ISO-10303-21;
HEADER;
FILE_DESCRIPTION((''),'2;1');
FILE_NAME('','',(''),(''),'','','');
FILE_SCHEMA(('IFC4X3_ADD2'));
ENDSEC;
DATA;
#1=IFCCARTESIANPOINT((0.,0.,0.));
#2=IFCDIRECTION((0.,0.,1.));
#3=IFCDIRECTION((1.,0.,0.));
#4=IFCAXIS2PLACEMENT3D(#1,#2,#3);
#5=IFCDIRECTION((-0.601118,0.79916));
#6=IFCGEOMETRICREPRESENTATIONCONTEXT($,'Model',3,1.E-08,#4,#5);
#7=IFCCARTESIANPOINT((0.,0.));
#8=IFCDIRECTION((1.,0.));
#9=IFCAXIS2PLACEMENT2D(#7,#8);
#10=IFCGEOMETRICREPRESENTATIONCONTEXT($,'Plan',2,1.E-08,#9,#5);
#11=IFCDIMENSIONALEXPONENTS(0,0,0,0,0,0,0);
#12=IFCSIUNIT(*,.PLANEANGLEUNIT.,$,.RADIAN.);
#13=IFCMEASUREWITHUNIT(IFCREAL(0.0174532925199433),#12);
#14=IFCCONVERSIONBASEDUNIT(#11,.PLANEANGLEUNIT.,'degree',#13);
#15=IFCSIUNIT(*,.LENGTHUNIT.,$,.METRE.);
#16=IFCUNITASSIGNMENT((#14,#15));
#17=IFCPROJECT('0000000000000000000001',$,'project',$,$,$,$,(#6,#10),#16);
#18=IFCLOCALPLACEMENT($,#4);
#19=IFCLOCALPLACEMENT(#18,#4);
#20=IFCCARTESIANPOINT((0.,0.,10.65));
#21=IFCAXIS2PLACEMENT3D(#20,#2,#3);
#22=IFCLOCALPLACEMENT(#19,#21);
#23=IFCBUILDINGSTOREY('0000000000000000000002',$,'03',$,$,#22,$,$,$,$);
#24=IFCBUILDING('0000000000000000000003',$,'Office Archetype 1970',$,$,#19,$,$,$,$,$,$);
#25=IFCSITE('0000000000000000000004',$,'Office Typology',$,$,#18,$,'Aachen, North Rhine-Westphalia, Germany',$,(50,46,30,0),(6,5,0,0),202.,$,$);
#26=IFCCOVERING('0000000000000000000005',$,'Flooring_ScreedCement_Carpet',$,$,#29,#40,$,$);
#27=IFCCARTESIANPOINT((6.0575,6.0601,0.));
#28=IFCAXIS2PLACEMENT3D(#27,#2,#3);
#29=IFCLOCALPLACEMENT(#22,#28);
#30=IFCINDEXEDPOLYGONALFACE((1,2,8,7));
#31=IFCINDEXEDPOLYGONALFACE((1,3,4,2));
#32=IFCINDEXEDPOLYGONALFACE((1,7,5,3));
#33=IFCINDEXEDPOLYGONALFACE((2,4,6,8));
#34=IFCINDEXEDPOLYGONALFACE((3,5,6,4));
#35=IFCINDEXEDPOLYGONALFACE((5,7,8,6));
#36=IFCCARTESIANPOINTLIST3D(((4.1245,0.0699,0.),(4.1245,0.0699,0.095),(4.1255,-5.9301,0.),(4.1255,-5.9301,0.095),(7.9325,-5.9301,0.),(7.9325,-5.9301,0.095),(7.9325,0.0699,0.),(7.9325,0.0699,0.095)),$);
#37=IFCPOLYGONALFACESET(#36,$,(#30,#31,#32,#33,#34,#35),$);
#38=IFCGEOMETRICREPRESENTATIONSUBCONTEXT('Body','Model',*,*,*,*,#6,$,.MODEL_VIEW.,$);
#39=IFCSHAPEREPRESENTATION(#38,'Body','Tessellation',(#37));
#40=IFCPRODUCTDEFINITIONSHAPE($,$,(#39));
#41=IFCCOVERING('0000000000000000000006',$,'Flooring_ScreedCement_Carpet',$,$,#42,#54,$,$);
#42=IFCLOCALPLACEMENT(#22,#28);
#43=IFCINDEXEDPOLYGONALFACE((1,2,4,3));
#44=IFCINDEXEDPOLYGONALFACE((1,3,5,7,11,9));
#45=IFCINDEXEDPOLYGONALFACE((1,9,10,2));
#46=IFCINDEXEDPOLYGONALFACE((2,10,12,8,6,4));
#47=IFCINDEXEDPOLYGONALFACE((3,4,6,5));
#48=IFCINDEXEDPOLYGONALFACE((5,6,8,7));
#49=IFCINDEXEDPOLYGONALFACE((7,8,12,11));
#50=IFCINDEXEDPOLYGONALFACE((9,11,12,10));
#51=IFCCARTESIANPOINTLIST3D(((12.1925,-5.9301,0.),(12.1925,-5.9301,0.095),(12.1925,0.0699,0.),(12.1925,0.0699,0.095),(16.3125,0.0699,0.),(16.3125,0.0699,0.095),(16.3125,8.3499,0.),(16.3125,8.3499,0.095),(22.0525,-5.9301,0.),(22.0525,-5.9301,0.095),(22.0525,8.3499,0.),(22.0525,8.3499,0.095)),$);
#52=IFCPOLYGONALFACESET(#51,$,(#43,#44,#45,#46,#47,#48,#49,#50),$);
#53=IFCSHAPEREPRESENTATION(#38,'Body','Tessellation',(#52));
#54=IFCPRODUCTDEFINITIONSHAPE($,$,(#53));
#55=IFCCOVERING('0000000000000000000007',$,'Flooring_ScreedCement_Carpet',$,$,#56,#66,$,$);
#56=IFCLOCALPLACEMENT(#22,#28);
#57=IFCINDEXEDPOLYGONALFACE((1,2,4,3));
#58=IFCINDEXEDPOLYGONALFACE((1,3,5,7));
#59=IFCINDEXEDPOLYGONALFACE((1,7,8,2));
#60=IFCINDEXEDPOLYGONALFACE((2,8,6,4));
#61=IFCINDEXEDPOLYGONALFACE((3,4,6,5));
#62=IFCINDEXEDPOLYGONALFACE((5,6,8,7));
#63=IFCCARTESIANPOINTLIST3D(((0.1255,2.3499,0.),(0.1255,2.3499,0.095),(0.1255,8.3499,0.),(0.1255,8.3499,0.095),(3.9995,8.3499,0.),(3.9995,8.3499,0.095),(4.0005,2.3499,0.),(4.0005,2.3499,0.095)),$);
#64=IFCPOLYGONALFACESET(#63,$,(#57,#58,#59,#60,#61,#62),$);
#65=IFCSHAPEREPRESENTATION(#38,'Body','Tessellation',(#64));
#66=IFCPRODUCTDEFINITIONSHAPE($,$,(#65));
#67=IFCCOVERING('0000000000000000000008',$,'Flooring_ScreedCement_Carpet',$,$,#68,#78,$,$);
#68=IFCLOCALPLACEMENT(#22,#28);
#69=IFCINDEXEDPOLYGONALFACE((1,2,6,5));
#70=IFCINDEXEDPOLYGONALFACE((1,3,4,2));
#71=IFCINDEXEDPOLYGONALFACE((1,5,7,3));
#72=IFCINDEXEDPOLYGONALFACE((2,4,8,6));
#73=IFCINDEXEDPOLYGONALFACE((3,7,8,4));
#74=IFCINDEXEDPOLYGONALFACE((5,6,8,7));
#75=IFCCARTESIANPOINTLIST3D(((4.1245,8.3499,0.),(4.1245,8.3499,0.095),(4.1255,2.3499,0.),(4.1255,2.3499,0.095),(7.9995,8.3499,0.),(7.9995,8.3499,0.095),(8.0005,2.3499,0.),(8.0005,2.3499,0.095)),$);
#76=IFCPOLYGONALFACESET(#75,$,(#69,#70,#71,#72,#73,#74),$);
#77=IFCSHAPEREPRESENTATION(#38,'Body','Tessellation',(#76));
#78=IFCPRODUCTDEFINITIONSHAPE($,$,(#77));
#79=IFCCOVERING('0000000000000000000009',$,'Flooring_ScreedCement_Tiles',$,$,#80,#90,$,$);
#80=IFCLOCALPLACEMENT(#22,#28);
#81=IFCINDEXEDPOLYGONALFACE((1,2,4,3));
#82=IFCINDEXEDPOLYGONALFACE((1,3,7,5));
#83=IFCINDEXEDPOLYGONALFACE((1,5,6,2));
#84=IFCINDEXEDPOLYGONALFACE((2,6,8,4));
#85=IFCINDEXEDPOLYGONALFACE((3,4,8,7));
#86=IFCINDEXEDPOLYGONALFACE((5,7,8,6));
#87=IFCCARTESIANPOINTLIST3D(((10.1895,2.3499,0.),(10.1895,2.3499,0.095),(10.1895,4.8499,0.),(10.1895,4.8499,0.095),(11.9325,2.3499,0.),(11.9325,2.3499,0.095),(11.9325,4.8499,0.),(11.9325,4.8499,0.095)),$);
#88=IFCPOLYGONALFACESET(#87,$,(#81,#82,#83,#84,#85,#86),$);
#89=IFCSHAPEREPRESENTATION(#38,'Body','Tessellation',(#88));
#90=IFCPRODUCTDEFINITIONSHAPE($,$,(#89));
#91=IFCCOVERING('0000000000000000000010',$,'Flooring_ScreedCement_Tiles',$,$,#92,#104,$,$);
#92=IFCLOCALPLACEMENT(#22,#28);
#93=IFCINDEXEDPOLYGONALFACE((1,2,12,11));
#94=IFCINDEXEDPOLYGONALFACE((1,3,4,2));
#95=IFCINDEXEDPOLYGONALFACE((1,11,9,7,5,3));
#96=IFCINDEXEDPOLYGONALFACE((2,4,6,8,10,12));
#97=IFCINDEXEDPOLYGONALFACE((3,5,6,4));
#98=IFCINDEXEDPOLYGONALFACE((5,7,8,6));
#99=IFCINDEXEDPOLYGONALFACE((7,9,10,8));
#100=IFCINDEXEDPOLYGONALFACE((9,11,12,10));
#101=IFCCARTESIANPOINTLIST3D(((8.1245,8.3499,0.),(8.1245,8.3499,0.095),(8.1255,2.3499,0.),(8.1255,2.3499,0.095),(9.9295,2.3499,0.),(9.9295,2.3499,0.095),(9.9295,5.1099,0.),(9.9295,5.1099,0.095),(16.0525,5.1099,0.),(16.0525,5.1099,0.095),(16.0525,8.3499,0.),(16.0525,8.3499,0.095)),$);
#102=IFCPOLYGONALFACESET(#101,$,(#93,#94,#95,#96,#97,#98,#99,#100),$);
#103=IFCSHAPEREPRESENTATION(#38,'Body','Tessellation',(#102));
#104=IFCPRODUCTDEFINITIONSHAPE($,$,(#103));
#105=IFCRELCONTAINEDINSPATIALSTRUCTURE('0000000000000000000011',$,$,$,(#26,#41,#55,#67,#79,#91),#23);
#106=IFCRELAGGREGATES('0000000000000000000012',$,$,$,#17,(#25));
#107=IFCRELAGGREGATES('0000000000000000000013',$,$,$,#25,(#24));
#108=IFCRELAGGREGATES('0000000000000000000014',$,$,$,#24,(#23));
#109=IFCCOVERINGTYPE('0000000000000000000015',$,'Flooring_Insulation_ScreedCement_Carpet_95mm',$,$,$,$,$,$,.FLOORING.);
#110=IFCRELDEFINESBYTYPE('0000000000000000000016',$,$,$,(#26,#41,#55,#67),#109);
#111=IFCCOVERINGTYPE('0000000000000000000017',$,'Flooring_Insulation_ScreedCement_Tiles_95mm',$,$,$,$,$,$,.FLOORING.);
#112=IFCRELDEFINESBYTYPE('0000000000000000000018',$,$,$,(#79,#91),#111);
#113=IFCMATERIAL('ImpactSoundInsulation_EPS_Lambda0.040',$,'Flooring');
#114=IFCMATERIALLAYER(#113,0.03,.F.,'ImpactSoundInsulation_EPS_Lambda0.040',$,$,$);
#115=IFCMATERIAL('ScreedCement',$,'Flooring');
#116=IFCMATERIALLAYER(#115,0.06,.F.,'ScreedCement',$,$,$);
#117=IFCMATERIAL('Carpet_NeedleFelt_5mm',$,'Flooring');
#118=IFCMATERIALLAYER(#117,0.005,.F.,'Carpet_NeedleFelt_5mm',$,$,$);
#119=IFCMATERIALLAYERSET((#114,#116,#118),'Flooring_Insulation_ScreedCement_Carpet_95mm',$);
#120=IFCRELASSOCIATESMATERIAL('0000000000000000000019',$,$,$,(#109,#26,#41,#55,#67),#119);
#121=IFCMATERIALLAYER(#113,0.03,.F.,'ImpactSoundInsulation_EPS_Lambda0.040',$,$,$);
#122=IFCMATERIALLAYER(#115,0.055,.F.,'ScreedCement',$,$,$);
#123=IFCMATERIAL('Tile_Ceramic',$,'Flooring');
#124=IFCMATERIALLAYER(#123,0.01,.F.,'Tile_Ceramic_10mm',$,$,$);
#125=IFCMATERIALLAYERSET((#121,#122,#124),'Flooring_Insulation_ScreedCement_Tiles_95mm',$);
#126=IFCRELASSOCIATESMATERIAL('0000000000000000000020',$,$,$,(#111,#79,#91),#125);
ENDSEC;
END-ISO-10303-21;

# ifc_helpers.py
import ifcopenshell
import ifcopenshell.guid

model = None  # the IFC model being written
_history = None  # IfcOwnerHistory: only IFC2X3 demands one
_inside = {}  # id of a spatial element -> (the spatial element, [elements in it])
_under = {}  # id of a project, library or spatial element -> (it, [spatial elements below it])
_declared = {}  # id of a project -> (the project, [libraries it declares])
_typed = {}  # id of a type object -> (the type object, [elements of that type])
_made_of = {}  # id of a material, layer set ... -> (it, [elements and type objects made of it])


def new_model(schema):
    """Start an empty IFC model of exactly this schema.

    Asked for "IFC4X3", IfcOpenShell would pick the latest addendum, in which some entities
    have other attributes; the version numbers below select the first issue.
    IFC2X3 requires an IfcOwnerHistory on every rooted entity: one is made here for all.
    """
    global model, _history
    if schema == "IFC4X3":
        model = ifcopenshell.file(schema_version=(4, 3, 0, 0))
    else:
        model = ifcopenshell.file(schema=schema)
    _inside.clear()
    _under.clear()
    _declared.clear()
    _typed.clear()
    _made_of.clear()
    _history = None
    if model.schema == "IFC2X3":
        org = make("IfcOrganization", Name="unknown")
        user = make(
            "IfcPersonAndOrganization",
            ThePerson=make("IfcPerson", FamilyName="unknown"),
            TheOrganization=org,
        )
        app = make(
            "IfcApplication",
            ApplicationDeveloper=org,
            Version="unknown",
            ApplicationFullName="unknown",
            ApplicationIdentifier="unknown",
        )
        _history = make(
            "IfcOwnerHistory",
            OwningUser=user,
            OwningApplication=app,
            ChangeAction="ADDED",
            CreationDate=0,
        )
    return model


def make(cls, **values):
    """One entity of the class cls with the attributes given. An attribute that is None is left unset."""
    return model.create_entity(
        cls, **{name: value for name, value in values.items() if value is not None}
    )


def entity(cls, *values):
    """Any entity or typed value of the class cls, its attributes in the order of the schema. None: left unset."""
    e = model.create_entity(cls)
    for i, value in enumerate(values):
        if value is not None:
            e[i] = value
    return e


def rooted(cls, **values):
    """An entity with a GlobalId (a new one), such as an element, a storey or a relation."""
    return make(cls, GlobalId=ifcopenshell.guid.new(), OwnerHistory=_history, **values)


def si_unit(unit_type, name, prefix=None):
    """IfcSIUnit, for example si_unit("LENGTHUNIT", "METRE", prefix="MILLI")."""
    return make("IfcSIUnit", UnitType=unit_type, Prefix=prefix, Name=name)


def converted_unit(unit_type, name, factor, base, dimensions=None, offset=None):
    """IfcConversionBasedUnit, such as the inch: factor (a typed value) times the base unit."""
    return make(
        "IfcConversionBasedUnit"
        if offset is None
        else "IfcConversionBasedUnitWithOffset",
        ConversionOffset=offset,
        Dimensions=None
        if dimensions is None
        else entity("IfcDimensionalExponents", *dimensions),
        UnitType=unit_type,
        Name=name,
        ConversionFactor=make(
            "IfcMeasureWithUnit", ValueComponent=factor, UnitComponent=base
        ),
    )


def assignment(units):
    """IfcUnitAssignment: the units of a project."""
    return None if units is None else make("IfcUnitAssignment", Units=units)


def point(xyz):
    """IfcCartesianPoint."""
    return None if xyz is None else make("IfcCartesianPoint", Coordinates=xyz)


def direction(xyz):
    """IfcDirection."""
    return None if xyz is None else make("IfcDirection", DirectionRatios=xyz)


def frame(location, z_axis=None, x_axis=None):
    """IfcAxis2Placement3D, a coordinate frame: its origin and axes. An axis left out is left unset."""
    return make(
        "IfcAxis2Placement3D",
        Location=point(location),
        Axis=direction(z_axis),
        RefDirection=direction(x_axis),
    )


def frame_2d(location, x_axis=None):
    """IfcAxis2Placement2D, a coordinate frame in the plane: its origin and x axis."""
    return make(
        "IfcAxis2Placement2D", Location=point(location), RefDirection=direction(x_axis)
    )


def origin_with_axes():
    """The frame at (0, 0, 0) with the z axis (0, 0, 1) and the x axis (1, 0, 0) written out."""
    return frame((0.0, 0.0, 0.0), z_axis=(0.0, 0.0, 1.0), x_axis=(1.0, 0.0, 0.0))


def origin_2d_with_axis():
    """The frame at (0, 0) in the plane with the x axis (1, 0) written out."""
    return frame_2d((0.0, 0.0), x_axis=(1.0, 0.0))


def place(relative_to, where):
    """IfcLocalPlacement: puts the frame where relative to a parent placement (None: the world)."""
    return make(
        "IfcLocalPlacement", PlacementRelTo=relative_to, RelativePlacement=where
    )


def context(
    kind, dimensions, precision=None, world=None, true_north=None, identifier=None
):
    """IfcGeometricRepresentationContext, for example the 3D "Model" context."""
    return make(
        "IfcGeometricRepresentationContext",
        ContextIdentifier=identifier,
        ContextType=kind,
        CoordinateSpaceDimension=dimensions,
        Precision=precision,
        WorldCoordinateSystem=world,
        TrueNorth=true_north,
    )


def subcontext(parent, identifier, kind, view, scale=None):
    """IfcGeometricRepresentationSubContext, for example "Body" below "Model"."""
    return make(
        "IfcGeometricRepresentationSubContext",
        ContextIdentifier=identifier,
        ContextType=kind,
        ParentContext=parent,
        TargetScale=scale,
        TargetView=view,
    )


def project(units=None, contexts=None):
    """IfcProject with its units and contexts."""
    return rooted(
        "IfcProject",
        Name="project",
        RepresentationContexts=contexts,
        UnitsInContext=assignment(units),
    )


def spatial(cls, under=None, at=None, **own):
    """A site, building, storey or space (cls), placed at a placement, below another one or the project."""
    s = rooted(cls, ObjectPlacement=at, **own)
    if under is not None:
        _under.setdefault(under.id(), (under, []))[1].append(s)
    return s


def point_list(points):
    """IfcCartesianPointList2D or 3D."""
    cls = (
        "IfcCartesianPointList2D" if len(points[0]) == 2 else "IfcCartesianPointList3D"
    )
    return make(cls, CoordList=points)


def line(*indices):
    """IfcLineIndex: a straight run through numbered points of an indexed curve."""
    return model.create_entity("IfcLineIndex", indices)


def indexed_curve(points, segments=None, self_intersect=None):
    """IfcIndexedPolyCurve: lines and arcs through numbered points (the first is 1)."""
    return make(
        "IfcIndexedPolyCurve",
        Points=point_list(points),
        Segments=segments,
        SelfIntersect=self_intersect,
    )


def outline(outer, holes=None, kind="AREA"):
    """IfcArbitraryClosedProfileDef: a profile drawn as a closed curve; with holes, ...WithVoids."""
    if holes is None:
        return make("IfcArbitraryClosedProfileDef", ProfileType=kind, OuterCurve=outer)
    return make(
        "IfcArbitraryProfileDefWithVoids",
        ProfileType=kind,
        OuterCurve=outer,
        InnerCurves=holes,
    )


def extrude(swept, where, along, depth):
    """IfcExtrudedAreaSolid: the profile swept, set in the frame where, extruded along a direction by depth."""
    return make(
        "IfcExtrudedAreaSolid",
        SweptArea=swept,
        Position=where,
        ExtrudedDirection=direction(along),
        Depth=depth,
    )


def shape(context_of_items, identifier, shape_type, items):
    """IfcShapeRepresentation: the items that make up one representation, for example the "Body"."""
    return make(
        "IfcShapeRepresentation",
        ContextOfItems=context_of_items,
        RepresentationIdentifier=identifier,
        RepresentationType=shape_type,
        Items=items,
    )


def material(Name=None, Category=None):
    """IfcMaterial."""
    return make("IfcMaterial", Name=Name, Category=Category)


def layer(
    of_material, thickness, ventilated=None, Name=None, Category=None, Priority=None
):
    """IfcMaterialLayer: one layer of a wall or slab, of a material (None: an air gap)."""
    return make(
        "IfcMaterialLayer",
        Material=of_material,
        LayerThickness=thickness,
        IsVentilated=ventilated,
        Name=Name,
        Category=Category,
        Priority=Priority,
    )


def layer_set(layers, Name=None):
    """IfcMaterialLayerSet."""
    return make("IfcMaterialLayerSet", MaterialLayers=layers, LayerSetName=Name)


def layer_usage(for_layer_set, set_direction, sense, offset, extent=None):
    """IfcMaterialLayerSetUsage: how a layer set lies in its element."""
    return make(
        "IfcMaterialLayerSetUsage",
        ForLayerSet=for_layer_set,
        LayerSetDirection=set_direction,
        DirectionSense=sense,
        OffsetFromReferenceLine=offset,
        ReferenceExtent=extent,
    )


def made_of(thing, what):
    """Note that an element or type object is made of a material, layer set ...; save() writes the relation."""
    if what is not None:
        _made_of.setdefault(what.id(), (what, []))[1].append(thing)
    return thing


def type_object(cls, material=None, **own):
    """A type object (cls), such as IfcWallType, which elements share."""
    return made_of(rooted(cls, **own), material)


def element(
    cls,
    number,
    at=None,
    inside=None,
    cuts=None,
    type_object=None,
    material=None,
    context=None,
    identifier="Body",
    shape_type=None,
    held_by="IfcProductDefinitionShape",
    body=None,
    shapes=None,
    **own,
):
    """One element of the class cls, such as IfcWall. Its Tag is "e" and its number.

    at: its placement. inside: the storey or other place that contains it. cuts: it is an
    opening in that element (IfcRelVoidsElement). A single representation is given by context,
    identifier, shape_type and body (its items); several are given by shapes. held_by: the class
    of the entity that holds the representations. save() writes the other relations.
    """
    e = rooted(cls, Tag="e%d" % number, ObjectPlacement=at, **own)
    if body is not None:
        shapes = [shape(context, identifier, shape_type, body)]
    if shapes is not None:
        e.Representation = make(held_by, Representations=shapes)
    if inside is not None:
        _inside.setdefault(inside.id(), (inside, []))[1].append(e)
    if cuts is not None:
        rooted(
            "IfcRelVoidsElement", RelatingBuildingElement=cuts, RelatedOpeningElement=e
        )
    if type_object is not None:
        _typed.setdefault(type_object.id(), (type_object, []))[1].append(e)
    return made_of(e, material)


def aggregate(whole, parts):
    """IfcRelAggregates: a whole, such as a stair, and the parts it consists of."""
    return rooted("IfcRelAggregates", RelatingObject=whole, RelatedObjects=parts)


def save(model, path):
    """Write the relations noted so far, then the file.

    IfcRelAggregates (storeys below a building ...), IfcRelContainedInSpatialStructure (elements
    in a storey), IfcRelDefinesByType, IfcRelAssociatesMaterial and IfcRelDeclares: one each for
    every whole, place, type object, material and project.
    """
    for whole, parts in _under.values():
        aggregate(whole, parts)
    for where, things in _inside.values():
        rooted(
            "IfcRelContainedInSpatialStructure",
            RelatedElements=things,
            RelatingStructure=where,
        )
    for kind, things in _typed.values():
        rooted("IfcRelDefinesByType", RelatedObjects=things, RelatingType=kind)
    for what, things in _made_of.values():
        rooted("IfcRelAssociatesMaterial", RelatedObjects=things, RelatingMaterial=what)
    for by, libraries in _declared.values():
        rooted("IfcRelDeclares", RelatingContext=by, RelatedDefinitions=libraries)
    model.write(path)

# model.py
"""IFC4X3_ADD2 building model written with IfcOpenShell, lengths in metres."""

from ifc_helpers import new_model, entity, si_unit, converted_unit, direction, frame, origin_with_axes, origin_2d_with_axis, place, context, subcontext, project, spatial, line, indexed_curve, outline, extrude, material, layer, layer_set, layer_usage, type_object, element, save


model = new_model("IFC4X3_ADD2")

# Units and contexts
model_context = context("Model", 3, precision=1e-08, world=origin_with_axes(), true_north=direction((-0.601118, 0.79916)))
plan_context = context("Plan", 2, precision=1e-08, world=origin_2d_with_axis(), true_north=direction((-0.601118, 0.79916)))
body_context = subcontext(model_context, "Body", "Model", "MODEL_VIEW")
ifc_project = project(units=[converted_unit("PLANEANGLEUNIT", "degree", entity("IfcReal", 0.0174532925199433), si_unit("PLANEANGLEUNIT", "RADIAN"), dimensions=[0, 0, 0, 0, 0, 0, 0]), si_unit("LENGTHUNIT", "METRE")], contexts=[model_context, plan_context])

# Site, building, storey
site_placement = place(None, origin_with_axes())
site = spatial("IfcSite", under=ifc_project, at=site_placement, Name="Office Typology", LongName="Aachen, North Rhine-Westphalia, Germany", RefLatitude=(50, 46, 30, 0), RefLongitude=(6, 5, 0, 0), RefElevation=202.0)
building_placement = place(site_placement, origin_with_axes())
building = spatial("IfcBuilding", under=site, at=building_placement, Name="Office Archetype 1970")
storey_placement = place(building_placement, frame((0.0, 0.0, 10.65), z_axis=(0.0, 0.0, 1.0), x_axis=(1.0, 0.0, 0.0)))
storey = spatial("IfcBuildingStorey", under=building, at=storey_placement, Name="03")

# Coverings
ifc_material_1 = material(Name="ImpactSoundInsulation_EPS_Lambda0.040", Category="Flooring")
ifc_layer_1 = layer(ifc_material_1, 0.03, ventilated=False, Name="ImpactSoundInsulation_EPS_Lambda0.040")
ifc_material_2 = material(Name="ScreedCement", Category="Flooring")
ifc_layer_2 = layer(ifc_material_2, 0.06, ventilated=False, Name="ScreedCement")
ifc_material_3 = material(Name="Carpet_NeedleFelt_5mm", Category="Flooring")
ifc_layer_3 = layer(ifc_material_3, 0.005, ventilated=False, Name="Carpet_NeedleFelt_5mm")
ifc_layer_set_1 = layer_set([ifc_layer_1, ifc_layer_2, ifc_layer_3], Name="Flooring_Insulation_ScreedCement_Carpet_95mm")
ifc_layer_usage_1 = layer_usage(ifc_layer_set_1, "AXIS3", "POSITIVE", 0.0)
covering_type_1 = type_object("IfcCoveringType", Name="Flooring_Insulation_ScreedCement_Carpet_95mm", PredefinedType="FLOORING", material=ifc_layer_set_1)
covering_1_placement = place(storey_placement, frame((6.0575, 6.0601, 0.0), z_axis=(0.0, 0.0, 1.0), x_axis=(1.0, 0.0, 0.0)))
element("IfcCovering", 1, at=covering_1_placement, inside=storey, type_object=covering_type_1, material=ifc_layer_usage_1, Name="Flooring_ScreedCement_Carpet", context=body_context, shape_type="SweptSolid", body=[
    extrude(outline(indexed_curve([(4.1245, 0.0699), (7.9325, 0.0699), (7.9325, -5.9301), (4.1255, -5.9301)], segments=[line(1, 2, 3, 4, 1)])), origin_with_axes(), (0.0, 0.0, 1.0), 0.095),
])
ifc_layer_usage_2 = layer_usage(ifc_layer_set_1, "AXIS3", "POSITIVE", 0.0)
covering_2_placement = place(storey_placement, frame((6.0575, 6.0601, 0.0), z_axis=(0.0, 0.0, 1.0), x_axis=(1.0, 0.0, 0.0)))
element("IfcCovering", 2, at=covering_2_placement, inside=storey, type_object=covering_type_1, material=ifc_layer_usage_2, Name="Flooring_ScreedCement_Carpet", context=body_context, shape_type="SweptSolid", body=[
    extrude(outline(indexed_curve([(16.3125, 8.3499), (22.0525, 8.3499), (22.0525, -5.9301), (12.1925, -5.9301), (12.1925, 0.0699), (16.3125, 0.0699)], segments=[line(1, 2, 3, 4, 5, 6, 1)])), origin_with_axes(), (0.0, 0.0, 1.0), 0.095),
])
ifc_layer_usage_3 = layer_usage(ifc_layer_set_1, "AXIS3", "POSITIVE", 0.0)
covering_3_placement = place(storey_placement, frame((6.0575, 6.0601, 0.0), z_axis=(0.0, 0.0, 1.0), x_axis=(1.0, 0.0, 0.0)))
element("IfcCovering", 3, at=covering_3_placement, inside=storey, type_object=covering_type_1, material=ifc_layer_usage_3, Name="Flooring_ScreedCement_Carpet", context=body_context, shape_type="SweptSolid", body=[
    extrude(outline(indexed_curve([(0.1255, 2.3499), (0.1255, 8.3499), (3.9995, 8.3499), (4.0005, 2.3499)], segments=[line(1, 2, 3, 4, 1)])), origin_with_axes(), (0.0, 0.0, 1.0), 0.095),
])
ifc_layer_usage_4 = layer_usage(ifc_layer_set_1, "AXIS3", "POSITIVE", 0.0)
covering_4_placement = place(storey_placement, frame((6.0575, 6.0601, 0.0), z_axis=(0.0, 0.0, 1.0), x_axis=(1.0, 0.0, 0.0)))
element("IfcCovering", 4, at=covering_4_placement, inside=storey, type_object=covering_type_1, material=ifc_layer_usage_4, Name="Flooring_ScreedCement_Carpet", context=body_context, shape_type="SweptSolid", body=[
    extrude(outline(indexed_curve([(4.1255, 2.3499), (4.1245, 8.3499), (7.9995, 8.3499), (8.0005, 2.3499)], segments=[line(1, 2, 3, 4, 1)])), origin_with_axes(), (0.0, 0.0, 1.0), 0.095),
])
ifc_layer_4 = layer(ifc_material_1, 0.03, ventilated=False, Name="ImpactSoundInsulation_EPS_Lambda0.040")
ifc_layer_5 = layer(ifc_material_2, 0.055, ventilated=False, Name="ScreedCement")
ifc_material_4 = material(Name="Tile_Ceramic", Category="Flooring")
ifc_layer_6 = layer(ifc_material_4, 0.01, ventilated=False, Name="Tile_Ceramic_10mm")
ifc_layer_set_2 = layer_set([ifc_layer_4, ifc_layer_5, ifc_layer_6], Name="Flooring_Insulation_ScreedCement_Tiles_95mm")
ifc_layer_usage_5 = layer_usage(ifc_layer_set_2, "AXIS3", "POSITIVE", 0.0)
covering_type_2 = type_object("IfcCoveringType", Name="Flooring_Insulation_ScreedCement_Tiles_95mm", PredefinedType="FLOORING", material=ifc_layer_set_2)
covering_5_placement = place(storey_placement, frame((6.0575, 6.0601, 0.0), z_axis=(0.0, 0.0, 1.0), x_axis=(1.0, 0.0, 0.0)))
element("IfcCovering", 5, at=covering_5_placement, inside=storey, type_object=covering_type_2, material=ifc_layer_usage_5, Name="Flooring_ScreedCement_Tiles", context=body_context, shape_type="SweptSolid", body=[
    extrude(outline(indexed_curve([(11.9325, 4.8499), (11.9325, 2.3499), (10.1895, 2.3499), (10.1895, 4.8499)], segments=[line(1, 2, 3, 4, 1)])), None, (0.0, 0.0, 1.0), 0.095),
])
ifc_layer_usage_6 = layer_usage(ifc_layer_set_2, "AXIS3", "POSITIVE", 0.0)
covering_6_placement = place(storey_placement, frame((6.0575, 6.0601, 0.0), z_axis=(0.0, 0.0, 1.0), x_axis=(1.0, 0.0, 0.0)))
element("IfcCovering", 6, at=covering_6_placement, inside=storey, type_object=covering_type_2, material=ifc_layer_usage_6, Name="Flooring_ScreedCement_Tiles", context=body_context, shape_type="SweptSolid", body=[
    extrude(outline(indexed_curve([(9.9295, 5.1099), (9.9295, 2.3499), (8.1255, 2.3499), (8.1245, 8.3499), (16.0525, 8.3499), (16.0525, 5.1099)], segments=[line(1, 2, 3, 4, 5, 6, 1)])), None, (0.0, 0.0, 1.0), 0.095),
])

save(model, "model.ifc")
